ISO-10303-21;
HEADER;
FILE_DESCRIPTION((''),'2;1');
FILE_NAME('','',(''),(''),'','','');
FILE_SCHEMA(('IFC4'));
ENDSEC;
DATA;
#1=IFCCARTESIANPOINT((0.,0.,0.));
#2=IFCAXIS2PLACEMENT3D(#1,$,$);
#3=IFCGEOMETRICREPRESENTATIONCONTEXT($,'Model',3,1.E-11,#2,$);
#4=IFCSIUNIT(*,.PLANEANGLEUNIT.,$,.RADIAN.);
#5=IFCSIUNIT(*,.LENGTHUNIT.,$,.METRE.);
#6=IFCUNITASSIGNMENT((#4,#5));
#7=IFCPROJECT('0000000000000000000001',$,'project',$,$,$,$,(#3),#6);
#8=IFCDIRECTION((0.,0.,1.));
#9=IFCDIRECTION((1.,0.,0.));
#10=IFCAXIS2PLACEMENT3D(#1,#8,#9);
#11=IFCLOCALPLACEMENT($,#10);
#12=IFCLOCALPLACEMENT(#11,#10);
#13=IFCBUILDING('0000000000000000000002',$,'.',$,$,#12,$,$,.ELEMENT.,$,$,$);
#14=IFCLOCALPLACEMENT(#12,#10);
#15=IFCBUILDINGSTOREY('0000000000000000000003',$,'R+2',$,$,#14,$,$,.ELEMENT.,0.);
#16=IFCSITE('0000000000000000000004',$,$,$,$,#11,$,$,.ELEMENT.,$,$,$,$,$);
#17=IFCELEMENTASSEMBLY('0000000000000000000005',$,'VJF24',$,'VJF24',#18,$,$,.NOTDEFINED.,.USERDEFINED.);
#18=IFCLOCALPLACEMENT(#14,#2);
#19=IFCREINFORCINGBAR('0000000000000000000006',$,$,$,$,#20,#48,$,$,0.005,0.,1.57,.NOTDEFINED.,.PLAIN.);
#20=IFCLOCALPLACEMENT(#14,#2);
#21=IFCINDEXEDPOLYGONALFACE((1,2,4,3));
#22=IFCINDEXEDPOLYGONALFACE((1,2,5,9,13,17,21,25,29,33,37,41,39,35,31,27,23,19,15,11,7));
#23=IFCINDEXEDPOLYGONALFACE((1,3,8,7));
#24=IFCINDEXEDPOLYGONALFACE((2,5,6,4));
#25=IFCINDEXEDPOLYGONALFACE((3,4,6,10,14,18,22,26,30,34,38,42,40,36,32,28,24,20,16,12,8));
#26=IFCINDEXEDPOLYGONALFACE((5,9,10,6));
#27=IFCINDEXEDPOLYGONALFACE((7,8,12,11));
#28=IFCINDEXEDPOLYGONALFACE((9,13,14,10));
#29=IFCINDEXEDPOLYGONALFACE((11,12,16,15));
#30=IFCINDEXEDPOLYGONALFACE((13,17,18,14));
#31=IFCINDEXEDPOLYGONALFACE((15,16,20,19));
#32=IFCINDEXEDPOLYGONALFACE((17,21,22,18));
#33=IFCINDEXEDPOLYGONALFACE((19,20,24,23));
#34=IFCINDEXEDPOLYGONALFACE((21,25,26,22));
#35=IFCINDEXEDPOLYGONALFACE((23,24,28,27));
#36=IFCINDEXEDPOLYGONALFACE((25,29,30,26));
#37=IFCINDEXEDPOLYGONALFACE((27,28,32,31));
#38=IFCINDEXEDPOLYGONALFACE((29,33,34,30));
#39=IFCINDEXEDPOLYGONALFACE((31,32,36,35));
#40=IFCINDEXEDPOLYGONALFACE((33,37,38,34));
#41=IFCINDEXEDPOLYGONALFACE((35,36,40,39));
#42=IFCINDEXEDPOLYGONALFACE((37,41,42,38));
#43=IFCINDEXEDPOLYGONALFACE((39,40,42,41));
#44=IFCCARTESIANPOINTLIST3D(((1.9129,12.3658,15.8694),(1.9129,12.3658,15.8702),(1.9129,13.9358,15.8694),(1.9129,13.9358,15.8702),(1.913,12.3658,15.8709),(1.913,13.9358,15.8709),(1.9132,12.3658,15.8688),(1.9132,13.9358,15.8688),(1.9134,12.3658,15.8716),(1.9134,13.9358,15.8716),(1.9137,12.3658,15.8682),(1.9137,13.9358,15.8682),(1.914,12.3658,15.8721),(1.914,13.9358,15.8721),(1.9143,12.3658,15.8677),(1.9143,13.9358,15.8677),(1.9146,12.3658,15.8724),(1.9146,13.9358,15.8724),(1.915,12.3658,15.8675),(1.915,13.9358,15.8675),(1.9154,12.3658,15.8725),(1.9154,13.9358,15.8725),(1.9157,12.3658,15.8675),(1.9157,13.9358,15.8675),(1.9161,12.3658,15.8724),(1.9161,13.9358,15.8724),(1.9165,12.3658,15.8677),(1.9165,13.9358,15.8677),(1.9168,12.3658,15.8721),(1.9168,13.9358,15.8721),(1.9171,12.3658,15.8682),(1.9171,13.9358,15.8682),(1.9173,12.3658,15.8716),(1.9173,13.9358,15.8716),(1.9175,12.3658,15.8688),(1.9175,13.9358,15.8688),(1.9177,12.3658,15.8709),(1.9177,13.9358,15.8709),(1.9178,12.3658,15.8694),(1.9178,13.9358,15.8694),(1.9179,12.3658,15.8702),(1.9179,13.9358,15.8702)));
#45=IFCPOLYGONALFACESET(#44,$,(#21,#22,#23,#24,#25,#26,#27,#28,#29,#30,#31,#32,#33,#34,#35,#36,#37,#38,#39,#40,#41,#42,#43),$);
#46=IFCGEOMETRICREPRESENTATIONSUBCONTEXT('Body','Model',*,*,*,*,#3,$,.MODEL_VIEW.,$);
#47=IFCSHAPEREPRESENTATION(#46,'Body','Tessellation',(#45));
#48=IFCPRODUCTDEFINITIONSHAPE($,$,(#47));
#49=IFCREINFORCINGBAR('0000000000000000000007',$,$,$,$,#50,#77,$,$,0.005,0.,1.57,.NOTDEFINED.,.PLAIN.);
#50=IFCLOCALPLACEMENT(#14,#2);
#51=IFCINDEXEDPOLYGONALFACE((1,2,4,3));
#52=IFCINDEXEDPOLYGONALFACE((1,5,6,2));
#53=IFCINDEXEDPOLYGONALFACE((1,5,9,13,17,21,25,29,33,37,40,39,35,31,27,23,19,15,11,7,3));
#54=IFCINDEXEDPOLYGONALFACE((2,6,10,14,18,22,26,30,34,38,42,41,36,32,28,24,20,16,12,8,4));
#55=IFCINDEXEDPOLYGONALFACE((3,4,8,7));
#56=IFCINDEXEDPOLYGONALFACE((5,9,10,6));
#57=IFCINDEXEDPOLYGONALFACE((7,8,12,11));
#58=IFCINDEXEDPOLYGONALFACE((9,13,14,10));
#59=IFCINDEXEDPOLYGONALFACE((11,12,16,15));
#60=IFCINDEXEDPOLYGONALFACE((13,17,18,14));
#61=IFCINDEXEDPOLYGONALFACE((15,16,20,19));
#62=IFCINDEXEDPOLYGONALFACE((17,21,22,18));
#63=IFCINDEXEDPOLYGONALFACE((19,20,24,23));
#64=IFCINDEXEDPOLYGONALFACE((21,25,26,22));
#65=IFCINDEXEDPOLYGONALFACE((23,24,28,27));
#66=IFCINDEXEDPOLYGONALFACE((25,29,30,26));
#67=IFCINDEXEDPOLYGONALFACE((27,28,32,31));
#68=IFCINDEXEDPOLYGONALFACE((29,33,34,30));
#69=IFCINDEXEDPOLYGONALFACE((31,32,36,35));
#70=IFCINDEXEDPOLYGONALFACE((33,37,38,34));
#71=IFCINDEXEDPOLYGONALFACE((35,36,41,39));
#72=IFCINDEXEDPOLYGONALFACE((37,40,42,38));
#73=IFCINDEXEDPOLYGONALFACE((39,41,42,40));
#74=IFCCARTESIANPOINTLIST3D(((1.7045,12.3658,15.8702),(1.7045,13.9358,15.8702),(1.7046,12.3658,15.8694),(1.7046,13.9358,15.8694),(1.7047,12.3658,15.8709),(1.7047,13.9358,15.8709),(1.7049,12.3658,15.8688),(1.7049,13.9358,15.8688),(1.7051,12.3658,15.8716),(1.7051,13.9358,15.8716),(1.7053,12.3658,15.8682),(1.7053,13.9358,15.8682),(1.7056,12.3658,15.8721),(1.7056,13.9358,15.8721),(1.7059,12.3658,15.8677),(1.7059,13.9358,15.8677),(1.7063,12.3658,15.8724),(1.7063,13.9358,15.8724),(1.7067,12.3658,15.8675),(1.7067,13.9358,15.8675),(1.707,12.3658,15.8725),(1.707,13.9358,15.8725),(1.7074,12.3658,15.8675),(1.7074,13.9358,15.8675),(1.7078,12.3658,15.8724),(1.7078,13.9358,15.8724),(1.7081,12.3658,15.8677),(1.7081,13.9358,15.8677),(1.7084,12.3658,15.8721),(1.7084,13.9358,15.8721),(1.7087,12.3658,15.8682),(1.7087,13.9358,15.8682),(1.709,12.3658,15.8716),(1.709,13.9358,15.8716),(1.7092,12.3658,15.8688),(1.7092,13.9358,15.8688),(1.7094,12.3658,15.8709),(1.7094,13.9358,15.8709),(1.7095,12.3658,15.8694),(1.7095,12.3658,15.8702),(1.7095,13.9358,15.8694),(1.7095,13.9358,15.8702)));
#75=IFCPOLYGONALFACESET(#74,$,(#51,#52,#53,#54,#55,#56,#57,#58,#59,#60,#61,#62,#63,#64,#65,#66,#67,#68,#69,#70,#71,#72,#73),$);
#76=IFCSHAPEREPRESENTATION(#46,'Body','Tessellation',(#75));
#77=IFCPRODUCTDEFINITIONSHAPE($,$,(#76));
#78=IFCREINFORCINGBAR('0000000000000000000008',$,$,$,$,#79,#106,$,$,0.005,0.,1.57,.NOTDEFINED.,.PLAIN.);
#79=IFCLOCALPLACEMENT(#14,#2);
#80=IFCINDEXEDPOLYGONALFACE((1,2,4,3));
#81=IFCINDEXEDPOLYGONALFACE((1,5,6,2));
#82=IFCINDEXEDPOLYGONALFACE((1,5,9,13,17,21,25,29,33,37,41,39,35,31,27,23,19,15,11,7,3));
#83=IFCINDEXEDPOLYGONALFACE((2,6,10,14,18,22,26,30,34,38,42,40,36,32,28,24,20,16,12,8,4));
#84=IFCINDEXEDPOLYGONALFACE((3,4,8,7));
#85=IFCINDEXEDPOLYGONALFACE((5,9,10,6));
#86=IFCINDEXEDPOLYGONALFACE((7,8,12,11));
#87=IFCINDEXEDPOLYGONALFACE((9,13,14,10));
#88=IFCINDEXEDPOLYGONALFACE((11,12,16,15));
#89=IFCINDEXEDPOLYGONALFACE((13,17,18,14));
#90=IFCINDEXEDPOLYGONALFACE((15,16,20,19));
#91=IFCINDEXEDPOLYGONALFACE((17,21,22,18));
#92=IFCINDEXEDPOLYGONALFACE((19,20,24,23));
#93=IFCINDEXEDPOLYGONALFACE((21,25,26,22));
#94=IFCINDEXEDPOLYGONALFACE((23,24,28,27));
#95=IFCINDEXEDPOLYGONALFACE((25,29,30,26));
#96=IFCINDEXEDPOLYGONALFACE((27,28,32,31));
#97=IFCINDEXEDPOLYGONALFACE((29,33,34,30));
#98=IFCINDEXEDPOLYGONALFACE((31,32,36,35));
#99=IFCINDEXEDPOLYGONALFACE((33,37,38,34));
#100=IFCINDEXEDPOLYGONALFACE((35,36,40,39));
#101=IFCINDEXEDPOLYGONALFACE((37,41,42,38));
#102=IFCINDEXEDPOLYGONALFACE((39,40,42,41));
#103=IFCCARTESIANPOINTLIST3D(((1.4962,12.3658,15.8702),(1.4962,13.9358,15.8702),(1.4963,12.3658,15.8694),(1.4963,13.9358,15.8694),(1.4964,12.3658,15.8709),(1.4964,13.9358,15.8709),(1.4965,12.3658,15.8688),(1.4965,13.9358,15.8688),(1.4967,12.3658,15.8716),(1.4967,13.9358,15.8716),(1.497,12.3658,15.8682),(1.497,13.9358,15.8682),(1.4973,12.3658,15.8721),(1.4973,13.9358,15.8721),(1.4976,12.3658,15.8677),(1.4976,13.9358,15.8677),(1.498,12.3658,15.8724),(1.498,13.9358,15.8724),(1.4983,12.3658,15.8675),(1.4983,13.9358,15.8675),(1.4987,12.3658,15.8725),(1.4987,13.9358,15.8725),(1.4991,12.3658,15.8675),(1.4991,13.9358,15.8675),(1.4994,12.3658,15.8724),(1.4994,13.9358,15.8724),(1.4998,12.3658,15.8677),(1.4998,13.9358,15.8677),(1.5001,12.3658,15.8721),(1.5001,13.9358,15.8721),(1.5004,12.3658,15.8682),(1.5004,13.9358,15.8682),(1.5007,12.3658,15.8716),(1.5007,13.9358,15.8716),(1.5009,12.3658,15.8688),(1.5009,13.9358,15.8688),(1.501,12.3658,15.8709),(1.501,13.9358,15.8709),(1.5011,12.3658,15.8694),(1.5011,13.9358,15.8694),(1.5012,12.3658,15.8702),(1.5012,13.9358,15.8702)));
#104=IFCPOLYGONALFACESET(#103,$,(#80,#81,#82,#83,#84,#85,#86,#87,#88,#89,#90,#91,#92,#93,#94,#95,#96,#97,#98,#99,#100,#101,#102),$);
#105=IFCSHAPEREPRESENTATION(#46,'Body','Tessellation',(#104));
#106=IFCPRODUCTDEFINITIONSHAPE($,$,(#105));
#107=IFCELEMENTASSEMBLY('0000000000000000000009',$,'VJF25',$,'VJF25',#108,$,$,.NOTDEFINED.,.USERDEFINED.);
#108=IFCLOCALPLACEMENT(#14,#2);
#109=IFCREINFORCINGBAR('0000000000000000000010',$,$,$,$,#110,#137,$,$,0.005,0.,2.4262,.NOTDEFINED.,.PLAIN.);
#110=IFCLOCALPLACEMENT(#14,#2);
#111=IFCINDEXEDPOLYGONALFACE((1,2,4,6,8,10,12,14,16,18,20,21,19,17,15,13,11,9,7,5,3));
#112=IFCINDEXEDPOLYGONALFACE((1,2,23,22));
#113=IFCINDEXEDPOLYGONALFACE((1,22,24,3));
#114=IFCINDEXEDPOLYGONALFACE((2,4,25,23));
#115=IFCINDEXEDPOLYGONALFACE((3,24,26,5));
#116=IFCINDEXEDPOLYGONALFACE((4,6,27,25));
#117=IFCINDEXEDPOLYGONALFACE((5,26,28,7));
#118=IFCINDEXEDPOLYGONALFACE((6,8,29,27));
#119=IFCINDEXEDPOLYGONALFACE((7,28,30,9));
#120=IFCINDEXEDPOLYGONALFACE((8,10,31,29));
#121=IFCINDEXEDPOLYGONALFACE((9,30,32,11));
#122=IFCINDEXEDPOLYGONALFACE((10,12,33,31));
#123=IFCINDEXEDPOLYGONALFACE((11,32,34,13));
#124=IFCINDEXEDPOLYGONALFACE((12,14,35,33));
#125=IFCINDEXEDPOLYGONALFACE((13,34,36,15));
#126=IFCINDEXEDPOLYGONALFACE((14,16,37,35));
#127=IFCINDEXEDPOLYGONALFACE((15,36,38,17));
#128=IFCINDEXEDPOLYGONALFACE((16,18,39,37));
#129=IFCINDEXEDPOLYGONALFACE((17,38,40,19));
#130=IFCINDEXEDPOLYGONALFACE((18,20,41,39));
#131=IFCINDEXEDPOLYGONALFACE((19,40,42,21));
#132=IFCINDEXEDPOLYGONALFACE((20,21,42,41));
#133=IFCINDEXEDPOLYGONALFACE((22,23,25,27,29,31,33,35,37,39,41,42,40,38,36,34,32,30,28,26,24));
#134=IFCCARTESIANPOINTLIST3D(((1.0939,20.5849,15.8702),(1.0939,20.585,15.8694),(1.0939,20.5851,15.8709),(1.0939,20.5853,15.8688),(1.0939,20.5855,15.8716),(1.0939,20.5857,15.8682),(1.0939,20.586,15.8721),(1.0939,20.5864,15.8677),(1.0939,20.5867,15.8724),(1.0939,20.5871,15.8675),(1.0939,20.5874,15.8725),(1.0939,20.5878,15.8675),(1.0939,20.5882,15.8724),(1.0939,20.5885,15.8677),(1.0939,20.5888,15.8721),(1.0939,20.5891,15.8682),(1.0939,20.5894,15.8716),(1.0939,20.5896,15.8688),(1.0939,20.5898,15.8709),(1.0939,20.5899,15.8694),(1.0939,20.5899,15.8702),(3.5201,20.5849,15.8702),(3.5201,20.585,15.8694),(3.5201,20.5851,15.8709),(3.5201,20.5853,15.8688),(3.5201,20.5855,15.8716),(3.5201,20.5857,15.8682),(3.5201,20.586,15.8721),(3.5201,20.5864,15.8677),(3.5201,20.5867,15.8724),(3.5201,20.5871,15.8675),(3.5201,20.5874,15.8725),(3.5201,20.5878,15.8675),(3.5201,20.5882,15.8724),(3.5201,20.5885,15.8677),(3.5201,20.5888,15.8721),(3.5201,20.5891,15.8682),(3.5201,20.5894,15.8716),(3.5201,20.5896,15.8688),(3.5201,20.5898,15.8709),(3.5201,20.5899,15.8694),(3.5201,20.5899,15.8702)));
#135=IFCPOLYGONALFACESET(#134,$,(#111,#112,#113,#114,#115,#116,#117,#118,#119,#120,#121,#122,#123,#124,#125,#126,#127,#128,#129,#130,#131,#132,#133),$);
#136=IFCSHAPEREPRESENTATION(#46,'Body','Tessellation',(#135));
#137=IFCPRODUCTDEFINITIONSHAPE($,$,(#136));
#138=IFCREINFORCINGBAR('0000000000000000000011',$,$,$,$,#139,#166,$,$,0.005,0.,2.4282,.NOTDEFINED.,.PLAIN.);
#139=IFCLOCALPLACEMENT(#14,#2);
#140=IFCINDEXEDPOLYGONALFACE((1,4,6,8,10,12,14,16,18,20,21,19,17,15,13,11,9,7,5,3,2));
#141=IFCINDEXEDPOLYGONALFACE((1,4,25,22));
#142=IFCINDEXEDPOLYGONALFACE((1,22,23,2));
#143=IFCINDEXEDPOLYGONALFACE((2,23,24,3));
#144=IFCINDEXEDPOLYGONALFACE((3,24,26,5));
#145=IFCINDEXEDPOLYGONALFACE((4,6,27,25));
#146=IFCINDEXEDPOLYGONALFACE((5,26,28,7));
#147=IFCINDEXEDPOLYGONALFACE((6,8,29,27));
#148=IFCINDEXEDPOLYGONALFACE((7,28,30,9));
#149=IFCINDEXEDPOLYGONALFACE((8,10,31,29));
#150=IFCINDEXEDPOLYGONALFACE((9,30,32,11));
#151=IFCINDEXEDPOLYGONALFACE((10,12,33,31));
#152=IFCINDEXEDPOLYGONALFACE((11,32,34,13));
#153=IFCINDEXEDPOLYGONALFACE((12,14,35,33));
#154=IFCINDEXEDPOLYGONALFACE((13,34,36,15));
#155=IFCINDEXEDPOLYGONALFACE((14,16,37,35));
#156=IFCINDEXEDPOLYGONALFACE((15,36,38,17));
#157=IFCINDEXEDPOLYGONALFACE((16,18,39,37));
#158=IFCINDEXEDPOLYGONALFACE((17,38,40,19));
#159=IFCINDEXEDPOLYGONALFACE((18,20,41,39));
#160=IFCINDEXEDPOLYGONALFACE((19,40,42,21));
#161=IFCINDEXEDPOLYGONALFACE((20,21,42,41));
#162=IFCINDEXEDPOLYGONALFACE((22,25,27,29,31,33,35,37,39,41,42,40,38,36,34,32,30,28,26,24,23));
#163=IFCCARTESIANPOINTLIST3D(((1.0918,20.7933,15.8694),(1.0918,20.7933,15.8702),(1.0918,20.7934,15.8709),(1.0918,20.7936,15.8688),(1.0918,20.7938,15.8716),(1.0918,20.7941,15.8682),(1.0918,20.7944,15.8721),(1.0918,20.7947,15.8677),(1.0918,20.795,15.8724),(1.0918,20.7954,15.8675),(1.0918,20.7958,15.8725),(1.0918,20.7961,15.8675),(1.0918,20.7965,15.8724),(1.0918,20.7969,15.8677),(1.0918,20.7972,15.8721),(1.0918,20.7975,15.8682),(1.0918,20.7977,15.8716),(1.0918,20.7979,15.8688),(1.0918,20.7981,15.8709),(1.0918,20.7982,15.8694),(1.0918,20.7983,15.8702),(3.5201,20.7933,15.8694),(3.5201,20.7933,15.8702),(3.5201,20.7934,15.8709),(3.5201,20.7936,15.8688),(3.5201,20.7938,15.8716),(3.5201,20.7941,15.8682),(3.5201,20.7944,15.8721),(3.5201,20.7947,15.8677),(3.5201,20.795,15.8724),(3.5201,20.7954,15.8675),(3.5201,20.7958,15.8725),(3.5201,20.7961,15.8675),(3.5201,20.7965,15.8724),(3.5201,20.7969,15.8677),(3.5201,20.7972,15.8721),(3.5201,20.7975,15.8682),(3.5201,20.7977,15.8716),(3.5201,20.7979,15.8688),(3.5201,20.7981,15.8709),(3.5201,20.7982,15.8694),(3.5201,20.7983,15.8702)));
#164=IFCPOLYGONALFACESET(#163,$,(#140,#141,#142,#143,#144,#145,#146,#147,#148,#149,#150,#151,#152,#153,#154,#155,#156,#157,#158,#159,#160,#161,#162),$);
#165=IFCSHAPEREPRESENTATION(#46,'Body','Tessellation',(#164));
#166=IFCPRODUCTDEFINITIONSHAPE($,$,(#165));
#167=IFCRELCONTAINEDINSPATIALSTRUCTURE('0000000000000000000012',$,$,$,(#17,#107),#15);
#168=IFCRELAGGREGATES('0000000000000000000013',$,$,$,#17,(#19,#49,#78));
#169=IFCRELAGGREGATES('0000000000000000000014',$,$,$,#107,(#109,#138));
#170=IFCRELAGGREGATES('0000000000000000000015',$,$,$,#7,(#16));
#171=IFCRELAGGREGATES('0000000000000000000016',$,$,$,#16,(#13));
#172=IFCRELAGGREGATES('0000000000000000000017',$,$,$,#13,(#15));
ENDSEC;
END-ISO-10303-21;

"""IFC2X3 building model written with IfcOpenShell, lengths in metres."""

from ifc_helpers import new_model, entity, si_unit, origin, origin_with_axes, place, context, subcontext, project, spatial, shape, element, aggregate, save


model = new_model("IFC2X3")

# Units and contexts
model_context = context("Model", 3, precision=1e-11, world=origin())
body_context = subcontext(model_context, "Body", "Model", "MODEL_VIEW")
ifc_project = project(units=[si_unit("PLANEANGLEUNIT", "RADIAN"), si_unit("LENGTHUNIT", "METRE")], contexts=[model_context])

# Site, building, storey
site_placement = place(None, origin_with_axes())
site = spatial("IfcSite", under=ifc_project, at=site_placement, CompositionType="ELEMENT")
building_placement = place(site_placement, origin_with_axes())
building = spatial("IfcBuilding", under=site, at=building_placement, Name=".", CompositionType="ELEMENT")
storey_placement = place(building_placement, origin_with_axes())
storey = spatial("IfcBuildingStorey", under=building, at=storey_placement, Name="R+2", CompositionType="ELEMENT", Elevation=0.0)

# Element assemblies, reinforcing bars
assembly_1_placement = place(storey_placement, origin_with_axes())
assembly_1 = element("IfcElementAssembly", 1, at=assembly_1_placement, inside=storey, Name="VJF24", ObjectType="VJF24", AssemblyPlace="NOTDEFINED", PredefinedType="USERDEFINED")
reinforcing_bar_1_placement = place(assembly_1_placement, origin_with_axes())
reinforcing_bar_1 = element("IfcReinforcingBar", 2, at=reinforcing_bar_1_placement, BarLength=1.57, BarRole="NOTDEFINED", BarSurface="PLAIN", CrossSectionArea=0.0, NominalDiameter=0.005, shapes=[
    shape(body_context, "Body", "AdvancedSweptSolid", [entity("IfcSweptDiskSolid", entity("IfcPolyline", [entity("IfcCartesianPoint", [1.9154, 12.3658, 15.87]), entity("IfcCartesianPoint", [1.9154, 13.9358, 15.87])]), 0.0025, None, 0.0, 1.57)]),
    shape(body_context, "Body", "AdvancedSweptSolid", [entity("IfcSweptDiskSolid", entity("IfcPolyline", [entity("IfcCartesianPoint", [1.9154, 12.3658, 15.87]), entity("IfcCartesianPoint", [1.9154, 13.9358, 15.87])]), 0.0025, None, 0.0, 1.57)]),
])
reinforcing_bar_2_placement = place(assembly_1_placement, origin_with_axes())
reinforcing_bar_2 = element("IfcReinforcingBar", 3, at=reinforcing_bar_2_placement, BarLength=1.57, BarRole="NOTDEFINED", BarSurface="PLAIN", CrossSectionArea=0.0, NominalDiameter=0.005, shapes=[
    shape(body_context, "Body", "AdvancedSweptSolid", [entity("IfcSweptDiskSolid", entity("IfcPolyline", [entity("IfcCartesianPoint", [1.707, 12.3658, 15.87]), entity("IfcCartesianPoint", [1.707, 13.9358, 15.87])]), 0.0025, None, 0.0, 1.57)]),
    shape(body_context, "Body", "AdvancedSweptSolid", [entity("IfcSweptDiskSolid", entity("IfcPolyline", [entity("IfcCartesianPoint", [1.707, 12.3658, 15.87]), entity("IfcCartesianPoint", [1.707, 13.9358, 15.87])]), 0.0025, None, 0.0, 1.57)]),
])
reinforcing_bar_3_placement = place(assembly_1_placement, origin_with_axes())
reinforcing_bar_3 = element("IfcReinforcingBar", 4, at=reinforcing_bar_3_placement, BarLength=1.57, BarRole="NOTDEFINED", BarSurface="PLAIN", CrossSectionArea=0.0, NominalDiameter=0.005, shapes=[
    shape(body_context, "Body", "AdvancedSweptSolid", [entity("IfcSweptDiskSolid", entity("IfcPolyline", [entity("IfcCartesianPoint", [1.4987, 12.3658, 15.87]), entity("IfcCartesianPoint", [1.4987, 13.9358, 15.87])]), 0.0025, None, 0.0, 1.57)]),
    shape(body_context, "Body", "AdvancedSweptSolid", [entity("IfcSweptDiskSolid", entity("IfcPolyline", [entity("IfcCartesianPoint", [1.4987, 12.3658, 15.87]), entity("IfcCartesianPoint", [1.4987, 13.9358, 15.87])]), 0.0025, None, 0.0, 1.57)]),
])
aggregate(assembly_1, [reinforcing_bar_1, reinforcing_bar_2, reinforcing_bar_3])
assembly_2_placement = place(storey_placement, origin_with_axes())
assembly_2 = element("IfcElementAssembly", 5, at=assembly_2_placement, inside=storey, Name="VJF25", ObjectType="VJF25", AssemblyPlace="NOTDEFINED", PredefinedType="USERDEFINED")
reinforcing_bar_4_placement = place(assembly_2_placement, origin_with_axes())
reinforcing_bar_4 = element("IfcReinforcingBar", 6, at=reinforcing_bar_4_placement, BarLength=2.4262, BarRole="NOTDEFINED", BarSurface="PLAIN", CrossSectionArea=0.0, NominalDiameter=0.005, shapes=[
    shape(body_context, "Body", "AdvancedSweptSolid", [entity("IfcSweptDiskSolid", entity("IfcPolyline", [entity("IfcCartesianPoint", [1.0939, 20.5874, 15.87]), entity("IfcCartesianPoint", [3.5201, 20.5874, 15.87])]), 0.0025, None, 0.0, 2.4262)]),
    shape(body_context, "Body", "AdvancedSweptSolid", [entity("IfcSweptDiskSolid", entity("IfcPolyline", [entity("IfcCartesianPoint", [1.0939, 20.5874, 15.87]), entity("IfcCartesianPoint", [3.5201, 20.5874, 15.87])]), 0.0025, None, 0.0, 2.4262)]),
])
reinforcing_bar_5_placement = place(assembly_2_placement, origin_with_axes())
reinforcing_bar_5 = element("IfcReinforcingBar", 7, at=reinforcing_bar_5_placement, BarLength=2.4282, BarRole="NOTDEFINED", BarSurface="PLAIN", CrossSectionArea=0.0, NominalDiameter=0.005, shapes=[
    shape(body_context, "Body", "AdvancedSweptSolid", [entity("IfcSweptDiskSolid", entity("IfcPolyline", [entity("IfcCartesianPoint", [1.0918, 20.7958, 15.87]), entity("IfcCartesianPoint", [3.5201, 20.7958, 15.87])]), 0.0025, None, 0.0, 2.4282)]),
    shape(body_context, "Body", "AdvancedSweptSolid", [entity("IfcSweptDiskSolid", entity("IfcPolyline", [entity("IfcCartesianPoint", [1.0918, 20.7958, 15.87]), entity("IfcCartesianPoint", [3.5201, 20.7958, 15.87])]), 0.0025, None, 0.0, 2.4282)]),
])
aggregate(assembly_2, [reinforcing_bar_4, reinforcing_bar_5])

save(model, "model.ifc")
